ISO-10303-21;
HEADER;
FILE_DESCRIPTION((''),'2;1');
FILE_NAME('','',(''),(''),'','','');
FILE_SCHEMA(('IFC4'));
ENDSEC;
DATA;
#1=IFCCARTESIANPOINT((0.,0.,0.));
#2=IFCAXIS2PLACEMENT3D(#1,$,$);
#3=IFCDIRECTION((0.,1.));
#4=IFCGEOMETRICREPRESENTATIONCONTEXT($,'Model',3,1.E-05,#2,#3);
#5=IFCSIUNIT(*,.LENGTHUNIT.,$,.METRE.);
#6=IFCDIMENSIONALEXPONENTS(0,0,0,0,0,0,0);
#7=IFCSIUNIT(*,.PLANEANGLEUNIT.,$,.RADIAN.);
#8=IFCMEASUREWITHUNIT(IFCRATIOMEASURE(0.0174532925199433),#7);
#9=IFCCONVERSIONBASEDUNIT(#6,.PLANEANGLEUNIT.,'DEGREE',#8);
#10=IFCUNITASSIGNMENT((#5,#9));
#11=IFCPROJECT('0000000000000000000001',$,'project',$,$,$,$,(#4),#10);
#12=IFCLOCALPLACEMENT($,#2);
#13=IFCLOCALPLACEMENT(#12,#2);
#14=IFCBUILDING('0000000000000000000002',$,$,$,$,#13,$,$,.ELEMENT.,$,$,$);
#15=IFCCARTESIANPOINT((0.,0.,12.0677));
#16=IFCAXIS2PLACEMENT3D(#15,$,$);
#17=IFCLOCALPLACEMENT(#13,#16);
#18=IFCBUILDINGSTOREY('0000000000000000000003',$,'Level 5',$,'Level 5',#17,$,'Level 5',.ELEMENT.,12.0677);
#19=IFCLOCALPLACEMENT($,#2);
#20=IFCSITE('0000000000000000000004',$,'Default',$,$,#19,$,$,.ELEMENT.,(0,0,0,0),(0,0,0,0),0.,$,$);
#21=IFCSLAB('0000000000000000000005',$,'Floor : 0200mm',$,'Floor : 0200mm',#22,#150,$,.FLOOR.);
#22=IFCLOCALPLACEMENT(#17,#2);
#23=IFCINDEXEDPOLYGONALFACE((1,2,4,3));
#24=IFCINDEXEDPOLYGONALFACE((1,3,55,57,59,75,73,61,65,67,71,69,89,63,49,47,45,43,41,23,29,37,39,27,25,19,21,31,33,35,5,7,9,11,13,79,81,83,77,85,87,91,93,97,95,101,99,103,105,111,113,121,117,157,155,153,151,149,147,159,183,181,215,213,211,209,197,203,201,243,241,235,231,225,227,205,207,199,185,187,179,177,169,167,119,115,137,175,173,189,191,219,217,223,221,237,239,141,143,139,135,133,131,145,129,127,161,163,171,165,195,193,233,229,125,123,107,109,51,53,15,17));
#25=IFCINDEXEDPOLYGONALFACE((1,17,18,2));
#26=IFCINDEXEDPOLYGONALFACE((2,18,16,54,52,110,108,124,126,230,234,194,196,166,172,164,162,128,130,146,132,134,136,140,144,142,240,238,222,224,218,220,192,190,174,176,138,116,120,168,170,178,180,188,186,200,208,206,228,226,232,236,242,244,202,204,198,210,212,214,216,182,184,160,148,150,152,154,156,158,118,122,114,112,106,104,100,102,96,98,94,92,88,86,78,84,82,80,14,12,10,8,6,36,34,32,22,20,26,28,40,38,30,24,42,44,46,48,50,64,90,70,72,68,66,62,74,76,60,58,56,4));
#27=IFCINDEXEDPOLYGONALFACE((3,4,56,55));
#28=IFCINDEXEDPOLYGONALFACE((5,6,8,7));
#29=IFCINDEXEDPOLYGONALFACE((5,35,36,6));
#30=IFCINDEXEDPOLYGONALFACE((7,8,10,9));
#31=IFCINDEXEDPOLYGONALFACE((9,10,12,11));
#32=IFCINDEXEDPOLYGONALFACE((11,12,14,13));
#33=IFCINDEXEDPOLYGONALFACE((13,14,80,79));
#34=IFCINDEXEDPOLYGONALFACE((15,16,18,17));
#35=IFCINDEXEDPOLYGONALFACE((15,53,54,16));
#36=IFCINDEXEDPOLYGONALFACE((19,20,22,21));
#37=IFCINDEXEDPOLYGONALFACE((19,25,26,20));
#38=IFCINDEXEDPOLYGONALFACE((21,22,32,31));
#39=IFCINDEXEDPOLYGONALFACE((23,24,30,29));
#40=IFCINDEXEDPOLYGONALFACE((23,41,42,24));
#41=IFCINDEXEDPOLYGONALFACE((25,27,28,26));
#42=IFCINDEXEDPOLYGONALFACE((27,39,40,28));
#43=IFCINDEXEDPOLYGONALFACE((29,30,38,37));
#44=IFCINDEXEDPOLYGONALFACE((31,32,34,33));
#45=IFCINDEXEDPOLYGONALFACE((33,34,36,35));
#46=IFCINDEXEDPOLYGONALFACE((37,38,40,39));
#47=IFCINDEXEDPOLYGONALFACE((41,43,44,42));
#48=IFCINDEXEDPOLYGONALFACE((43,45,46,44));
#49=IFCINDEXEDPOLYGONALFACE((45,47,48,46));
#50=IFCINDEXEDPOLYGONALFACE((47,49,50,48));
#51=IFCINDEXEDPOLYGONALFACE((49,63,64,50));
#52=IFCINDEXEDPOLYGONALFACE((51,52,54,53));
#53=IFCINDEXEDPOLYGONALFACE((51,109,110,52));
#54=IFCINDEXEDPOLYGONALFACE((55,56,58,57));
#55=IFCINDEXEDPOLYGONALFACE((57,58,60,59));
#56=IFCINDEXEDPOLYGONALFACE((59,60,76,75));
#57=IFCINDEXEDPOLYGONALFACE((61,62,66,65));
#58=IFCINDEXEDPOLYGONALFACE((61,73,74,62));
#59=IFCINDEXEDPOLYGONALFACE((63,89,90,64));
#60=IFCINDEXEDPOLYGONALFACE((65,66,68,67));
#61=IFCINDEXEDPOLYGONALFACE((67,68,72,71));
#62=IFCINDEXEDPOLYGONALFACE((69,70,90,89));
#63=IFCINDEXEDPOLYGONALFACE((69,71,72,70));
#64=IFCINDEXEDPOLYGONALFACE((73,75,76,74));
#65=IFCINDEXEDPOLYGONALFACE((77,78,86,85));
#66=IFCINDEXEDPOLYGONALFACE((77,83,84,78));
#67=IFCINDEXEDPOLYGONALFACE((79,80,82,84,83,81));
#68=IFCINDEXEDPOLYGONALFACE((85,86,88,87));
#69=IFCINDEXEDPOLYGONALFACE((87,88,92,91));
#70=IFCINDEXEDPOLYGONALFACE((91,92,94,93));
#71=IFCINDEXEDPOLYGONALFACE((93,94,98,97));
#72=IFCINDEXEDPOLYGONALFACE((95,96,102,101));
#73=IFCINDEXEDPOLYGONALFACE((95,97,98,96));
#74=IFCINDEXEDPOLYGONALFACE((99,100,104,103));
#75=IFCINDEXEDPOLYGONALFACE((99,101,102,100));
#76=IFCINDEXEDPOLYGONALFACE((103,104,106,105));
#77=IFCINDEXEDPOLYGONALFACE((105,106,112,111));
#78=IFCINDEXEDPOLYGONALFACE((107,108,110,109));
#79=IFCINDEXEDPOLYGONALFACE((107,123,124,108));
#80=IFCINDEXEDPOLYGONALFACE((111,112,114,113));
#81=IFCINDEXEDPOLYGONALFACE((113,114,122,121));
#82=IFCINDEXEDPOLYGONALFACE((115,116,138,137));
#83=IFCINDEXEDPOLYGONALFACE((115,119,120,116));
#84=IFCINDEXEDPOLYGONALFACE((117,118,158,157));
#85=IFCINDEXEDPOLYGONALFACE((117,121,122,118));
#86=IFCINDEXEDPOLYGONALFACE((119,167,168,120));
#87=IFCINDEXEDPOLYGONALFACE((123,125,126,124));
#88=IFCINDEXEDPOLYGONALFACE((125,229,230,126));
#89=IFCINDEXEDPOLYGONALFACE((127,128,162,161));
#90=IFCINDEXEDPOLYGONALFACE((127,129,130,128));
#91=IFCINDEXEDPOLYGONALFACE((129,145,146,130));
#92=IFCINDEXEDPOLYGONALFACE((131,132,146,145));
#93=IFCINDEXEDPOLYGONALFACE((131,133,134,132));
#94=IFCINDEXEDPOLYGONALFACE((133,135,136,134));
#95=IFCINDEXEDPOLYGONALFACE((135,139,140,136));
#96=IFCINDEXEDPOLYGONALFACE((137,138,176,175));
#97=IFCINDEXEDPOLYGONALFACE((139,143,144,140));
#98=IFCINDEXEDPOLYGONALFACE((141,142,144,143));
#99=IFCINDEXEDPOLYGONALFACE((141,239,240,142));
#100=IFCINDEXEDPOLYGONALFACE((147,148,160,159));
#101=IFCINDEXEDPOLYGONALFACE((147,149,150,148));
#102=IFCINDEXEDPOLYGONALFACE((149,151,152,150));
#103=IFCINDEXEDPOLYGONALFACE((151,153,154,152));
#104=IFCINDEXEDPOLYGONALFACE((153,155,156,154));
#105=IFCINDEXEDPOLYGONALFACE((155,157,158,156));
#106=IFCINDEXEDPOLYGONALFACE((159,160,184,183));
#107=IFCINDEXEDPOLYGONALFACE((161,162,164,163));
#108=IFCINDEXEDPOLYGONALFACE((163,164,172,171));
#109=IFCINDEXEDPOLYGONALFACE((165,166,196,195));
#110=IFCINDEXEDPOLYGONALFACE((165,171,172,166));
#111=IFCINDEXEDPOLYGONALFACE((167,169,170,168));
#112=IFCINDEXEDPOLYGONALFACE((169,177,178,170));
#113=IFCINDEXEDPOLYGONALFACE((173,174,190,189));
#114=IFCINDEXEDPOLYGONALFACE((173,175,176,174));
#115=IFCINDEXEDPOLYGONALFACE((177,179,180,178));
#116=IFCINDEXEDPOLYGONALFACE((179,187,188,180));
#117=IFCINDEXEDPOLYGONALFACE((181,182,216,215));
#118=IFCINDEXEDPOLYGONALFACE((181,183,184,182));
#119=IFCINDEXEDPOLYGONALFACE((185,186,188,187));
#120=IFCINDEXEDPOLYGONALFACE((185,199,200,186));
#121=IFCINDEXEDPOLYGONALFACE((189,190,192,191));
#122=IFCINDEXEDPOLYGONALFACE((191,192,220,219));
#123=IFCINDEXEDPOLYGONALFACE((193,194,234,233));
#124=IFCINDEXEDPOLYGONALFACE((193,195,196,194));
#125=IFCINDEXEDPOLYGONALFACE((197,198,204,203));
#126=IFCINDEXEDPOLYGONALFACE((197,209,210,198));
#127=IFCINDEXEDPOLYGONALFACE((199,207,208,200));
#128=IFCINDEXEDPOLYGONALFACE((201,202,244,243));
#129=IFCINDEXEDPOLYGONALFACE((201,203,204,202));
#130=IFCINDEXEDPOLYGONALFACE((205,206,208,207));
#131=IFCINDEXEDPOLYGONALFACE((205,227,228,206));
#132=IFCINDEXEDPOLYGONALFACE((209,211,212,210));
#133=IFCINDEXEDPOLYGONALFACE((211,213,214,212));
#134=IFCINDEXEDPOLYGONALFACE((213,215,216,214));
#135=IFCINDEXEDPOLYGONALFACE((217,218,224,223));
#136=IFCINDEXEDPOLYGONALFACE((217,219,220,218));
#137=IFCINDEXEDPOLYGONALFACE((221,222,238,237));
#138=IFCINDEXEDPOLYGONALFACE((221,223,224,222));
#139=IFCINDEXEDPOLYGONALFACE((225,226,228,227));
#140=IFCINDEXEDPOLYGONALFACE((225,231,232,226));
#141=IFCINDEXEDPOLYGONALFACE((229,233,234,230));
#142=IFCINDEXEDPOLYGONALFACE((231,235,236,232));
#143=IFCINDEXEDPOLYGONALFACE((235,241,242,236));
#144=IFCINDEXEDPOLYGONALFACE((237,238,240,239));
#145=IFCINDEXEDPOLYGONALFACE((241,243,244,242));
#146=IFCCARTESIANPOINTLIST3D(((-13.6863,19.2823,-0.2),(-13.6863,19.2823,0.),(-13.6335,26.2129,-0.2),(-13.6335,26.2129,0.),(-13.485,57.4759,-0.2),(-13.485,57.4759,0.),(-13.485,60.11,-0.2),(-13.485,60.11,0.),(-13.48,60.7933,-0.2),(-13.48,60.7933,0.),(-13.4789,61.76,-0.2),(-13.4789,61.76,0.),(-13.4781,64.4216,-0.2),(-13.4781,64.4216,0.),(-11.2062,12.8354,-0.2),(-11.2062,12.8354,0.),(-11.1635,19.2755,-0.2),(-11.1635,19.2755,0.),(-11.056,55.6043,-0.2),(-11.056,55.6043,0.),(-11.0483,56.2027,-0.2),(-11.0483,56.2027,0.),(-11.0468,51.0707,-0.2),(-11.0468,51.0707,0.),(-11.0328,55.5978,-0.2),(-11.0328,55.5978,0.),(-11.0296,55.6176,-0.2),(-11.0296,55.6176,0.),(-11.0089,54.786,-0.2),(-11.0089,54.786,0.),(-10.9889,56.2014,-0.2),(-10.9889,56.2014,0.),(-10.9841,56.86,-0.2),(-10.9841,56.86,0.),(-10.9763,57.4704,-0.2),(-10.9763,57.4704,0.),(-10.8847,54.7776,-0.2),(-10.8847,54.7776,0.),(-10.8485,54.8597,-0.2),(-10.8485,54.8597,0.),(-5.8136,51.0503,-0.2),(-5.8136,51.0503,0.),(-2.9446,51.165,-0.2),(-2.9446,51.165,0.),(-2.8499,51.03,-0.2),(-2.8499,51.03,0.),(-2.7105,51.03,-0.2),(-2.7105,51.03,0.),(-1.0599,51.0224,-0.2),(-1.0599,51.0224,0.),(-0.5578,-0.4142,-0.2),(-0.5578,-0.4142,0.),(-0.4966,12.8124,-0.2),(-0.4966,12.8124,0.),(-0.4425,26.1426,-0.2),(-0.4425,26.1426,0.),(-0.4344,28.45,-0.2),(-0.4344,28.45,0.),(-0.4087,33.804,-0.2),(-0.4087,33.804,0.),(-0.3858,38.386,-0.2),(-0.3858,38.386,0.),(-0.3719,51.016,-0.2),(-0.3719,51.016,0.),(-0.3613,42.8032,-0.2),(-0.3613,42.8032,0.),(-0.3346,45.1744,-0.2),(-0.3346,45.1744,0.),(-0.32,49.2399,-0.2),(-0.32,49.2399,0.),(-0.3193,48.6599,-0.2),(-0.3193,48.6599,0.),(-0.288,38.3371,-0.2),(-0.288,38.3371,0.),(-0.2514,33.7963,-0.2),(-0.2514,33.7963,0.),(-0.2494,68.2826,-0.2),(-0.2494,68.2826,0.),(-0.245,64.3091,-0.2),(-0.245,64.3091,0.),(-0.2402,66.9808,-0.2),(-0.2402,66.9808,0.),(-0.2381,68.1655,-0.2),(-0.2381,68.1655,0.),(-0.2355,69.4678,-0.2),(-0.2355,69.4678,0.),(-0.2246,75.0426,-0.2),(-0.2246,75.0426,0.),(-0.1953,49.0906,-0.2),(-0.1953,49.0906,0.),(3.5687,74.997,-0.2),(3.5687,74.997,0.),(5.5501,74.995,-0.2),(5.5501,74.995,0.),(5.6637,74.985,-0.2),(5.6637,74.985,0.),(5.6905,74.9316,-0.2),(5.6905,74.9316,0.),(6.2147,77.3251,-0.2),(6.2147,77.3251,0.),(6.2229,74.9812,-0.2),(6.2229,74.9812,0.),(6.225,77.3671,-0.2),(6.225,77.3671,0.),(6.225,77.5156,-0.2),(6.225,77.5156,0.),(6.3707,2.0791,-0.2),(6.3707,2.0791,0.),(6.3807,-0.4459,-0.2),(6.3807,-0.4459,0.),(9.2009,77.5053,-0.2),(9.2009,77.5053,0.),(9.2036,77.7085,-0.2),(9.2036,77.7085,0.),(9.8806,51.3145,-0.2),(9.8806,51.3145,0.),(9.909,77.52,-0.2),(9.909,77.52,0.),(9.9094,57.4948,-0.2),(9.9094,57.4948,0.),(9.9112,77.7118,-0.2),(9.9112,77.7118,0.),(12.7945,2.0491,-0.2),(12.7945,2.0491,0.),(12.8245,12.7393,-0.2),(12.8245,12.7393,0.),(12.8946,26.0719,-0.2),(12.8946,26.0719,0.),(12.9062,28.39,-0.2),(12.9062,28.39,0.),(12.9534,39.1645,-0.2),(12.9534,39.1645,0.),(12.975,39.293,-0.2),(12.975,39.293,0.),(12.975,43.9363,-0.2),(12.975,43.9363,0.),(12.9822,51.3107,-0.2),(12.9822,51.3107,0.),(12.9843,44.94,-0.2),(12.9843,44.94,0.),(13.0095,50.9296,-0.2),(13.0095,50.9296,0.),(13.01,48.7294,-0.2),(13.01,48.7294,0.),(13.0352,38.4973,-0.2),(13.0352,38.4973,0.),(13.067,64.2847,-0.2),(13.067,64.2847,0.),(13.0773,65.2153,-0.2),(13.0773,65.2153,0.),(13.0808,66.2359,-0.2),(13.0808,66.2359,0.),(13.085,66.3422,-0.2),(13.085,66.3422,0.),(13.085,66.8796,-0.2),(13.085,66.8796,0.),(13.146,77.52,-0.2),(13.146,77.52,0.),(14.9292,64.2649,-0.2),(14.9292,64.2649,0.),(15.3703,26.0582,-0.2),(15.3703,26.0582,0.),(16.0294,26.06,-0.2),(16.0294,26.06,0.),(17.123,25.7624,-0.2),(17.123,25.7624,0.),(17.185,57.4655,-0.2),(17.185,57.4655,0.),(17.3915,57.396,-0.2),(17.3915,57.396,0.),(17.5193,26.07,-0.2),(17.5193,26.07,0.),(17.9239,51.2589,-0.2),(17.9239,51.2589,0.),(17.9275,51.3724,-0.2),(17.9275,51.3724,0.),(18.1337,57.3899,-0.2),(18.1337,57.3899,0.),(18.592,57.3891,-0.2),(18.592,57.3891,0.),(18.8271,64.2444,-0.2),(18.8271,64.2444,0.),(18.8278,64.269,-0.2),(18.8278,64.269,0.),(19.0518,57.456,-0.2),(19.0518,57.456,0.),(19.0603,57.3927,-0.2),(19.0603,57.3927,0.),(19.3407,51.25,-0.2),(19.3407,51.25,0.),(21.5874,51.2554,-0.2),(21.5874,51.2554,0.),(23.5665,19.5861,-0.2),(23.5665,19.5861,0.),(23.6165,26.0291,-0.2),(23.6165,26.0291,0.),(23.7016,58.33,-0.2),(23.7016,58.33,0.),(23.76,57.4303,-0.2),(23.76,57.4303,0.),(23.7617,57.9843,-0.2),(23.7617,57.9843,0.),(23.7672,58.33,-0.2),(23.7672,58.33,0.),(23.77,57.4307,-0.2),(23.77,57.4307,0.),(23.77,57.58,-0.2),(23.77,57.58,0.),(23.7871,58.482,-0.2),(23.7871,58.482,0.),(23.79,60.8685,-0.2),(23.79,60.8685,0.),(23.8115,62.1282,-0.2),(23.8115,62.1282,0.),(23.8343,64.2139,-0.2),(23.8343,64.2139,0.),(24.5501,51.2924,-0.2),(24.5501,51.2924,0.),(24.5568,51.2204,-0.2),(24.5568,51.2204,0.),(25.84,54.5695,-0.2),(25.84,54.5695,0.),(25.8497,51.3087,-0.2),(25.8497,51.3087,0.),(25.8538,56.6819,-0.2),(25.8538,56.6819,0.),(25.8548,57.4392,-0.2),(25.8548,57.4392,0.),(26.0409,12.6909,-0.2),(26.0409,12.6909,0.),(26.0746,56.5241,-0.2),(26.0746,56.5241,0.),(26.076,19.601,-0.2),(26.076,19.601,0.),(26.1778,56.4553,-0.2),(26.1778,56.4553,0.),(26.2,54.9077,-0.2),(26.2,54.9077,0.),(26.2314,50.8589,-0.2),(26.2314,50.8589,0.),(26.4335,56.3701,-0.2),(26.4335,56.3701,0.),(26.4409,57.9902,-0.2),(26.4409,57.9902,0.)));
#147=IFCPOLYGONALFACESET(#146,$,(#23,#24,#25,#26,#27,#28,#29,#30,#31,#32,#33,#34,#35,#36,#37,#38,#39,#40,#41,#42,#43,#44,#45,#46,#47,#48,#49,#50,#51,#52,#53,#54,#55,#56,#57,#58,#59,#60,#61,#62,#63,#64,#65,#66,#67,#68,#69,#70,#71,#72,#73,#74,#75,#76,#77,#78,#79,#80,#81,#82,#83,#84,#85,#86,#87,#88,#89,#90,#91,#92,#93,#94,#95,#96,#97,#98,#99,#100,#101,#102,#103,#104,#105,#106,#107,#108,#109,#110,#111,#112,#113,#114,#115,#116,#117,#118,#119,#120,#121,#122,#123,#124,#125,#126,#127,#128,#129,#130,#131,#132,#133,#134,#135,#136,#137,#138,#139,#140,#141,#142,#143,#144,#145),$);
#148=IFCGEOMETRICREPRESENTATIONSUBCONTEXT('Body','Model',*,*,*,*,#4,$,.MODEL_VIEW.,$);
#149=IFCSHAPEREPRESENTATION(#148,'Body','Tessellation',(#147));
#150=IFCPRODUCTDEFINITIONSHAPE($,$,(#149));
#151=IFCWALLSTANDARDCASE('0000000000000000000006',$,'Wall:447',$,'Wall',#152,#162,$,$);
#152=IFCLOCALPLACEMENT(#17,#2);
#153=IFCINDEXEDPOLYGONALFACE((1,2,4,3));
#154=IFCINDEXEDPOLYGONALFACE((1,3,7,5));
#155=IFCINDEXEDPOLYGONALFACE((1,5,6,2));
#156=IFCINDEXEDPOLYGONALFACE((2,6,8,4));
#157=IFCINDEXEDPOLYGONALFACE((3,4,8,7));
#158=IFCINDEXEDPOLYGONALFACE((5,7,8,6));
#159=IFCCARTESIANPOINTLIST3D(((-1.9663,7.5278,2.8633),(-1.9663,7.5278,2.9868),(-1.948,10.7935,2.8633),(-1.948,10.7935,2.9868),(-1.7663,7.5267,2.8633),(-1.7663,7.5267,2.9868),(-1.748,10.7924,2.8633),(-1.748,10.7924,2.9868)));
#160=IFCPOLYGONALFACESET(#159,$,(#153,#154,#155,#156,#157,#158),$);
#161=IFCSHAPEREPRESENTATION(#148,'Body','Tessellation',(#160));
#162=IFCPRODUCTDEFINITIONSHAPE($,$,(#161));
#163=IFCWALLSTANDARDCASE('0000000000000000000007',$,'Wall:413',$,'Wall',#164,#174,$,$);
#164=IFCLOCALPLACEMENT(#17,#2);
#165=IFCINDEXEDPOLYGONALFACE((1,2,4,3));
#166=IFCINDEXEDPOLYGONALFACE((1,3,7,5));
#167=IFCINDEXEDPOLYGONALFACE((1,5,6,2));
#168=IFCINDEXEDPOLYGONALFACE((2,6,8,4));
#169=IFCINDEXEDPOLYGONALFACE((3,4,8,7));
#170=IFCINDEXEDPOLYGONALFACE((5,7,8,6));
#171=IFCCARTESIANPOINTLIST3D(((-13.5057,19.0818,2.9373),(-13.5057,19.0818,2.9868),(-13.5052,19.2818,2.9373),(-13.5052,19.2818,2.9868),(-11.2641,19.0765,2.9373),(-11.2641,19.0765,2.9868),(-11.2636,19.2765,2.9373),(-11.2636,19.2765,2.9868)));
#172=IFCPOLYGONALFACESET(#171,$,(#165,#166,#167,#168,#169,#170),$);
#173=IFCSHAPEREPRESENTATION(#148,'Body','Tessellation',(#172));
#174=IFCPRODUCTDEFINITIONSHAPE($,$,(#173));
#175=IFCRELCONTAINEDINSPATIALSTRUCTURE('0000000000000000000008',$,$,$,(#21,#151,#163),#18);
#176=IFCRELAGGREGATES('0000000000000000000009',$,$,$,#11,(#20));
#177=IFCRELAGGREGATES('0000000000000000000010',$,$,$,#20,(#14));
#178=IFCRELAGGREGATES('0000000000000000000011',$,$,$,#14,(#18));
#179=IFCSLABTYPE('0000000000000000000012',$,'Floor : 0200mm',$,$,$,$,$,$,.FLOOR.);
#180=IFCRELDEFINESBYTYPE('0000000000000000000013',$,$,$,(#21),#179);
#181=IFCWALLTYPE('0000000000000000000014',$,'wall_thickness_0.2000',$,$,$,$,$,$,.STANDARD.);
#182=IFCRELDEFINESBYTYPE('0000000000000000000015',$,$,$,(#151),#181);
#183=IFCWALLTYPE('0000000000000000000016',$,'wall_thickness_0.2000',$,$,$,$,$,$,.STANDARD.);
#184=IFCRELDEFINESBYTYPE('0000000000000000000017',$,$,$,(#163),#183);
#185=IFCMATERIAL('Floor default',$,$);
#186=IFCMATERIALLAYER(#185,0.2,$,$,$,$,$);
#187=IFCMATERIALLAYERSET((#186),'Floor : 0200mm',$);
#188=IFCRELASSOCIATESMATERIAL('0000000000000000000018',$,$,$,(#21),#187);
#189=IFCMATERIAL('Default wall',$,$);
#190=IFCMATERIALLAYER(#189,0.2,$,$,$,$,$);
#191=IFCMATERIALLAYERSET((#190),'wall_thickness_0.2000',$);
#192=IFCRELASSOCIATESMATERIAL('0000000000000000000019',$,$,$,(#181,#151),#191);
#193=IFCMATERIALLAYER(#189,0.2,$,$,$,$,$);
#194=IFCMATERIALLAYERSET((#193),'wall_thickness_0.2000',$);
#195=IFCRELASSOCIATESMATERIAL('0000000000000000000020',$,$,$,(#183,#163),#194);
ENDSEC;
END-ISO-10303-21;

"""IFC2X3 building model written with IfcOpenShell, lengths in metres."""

from ifc_helpers import new_model, entity, si_unit, converted_unit, direction, frame, origin, place, context, subcontext, project, spatial, polyline, outline, extrude, material, layer, layer_set, layer_usage, type_object, element, save


model = new_model("IFC2X3")

# Units and contexts
model_context = context("Model", 3, precision=1e-05, world=origin(), true_north=direction((0.0, 1.0)))
body_context = subcontext(model_context, "Body", "Model", "MODEL_VIEW")
ifc_project = project(units=[si_unit("LENGTHUNIT", "METRE"), converted_unit("PLANEANGLEUNIT", "DEGREE", entity("IfcRatioMeasure", 0.0174532925199433), si_unit("PLANEANGLEUNIT", "RADIAN"), dimensions=[0, 0, 0, 0, 0, 0, 0])], contexts=[model_context])

# Site, building, storey
site_placement = place(None, origin())
site = spatial("IfcSite", under=ifc_project, at=site_placement, Name="Default", CompositionType="ELEMENT", RefLatitude=(0, 0, 0, 0), RefLongitude=(0, 0, 0, 0), RefElevation=0.0)
placement_1 = place(None, origin())
building_placement = place(placement_1, origin())
building = spatial("IfcBuilding", under=site, at=building_placement, CompositionType="ELEMENT")
storey_placement = place(building_placement, frame((0.0, 0.0, 12.0677)))
storey = spatial("IfcBuildingStorey", under=building, at=storey_placement, Name="Level 5", ObjectType="Level 5", LongName="Level 5", CompositionType="ELEMENT", Elevation=12.0677)

# Slab
ifc_material_1 = material(Name="Floor default")
ifc_layer_1 = layer(ifc_material_1, 0.2)
ifc_layer_set_1 = layer_set([ifc_layer_1], Name="Floor : 0200mm")
ifc_layer_usage_1 = layer_usage(ifc_layer_set_1, "AXIS3", "POSITIVE", 0.0)
slab_type = type_object("IfcSlabType", Name="Floor : 0200mm", PredefinedType="FLOOR")
slab_placement = place(storey_placement, origin())
element("IfcSlab", 1, at=slab_placement, inside=storey, type_object=slab_type, material=ifc_layer_usage_1, Name="Floor : 0200mm", ObjectType="Floor : 0200mm", PredefinedType="FLOOR", context=body_context, shape_type="SweptSolid", body=[
    extrude(outline(polyline([(-0.4087, 33.804), (-0.2514, 33.7963), (-0.288, 38.3371), (-0.3858, 38.386), (-0.3613, 42.8032), (-0.3346, 45.1744), (-0.3193, 48.6599), (-0.32, 49.2399), (-0.1953, 49.0906), (-0.3719, 51.016), (-1.0599, 51.0224), (-2.7105, 51.03), (-2.8499, 51.03), (-2.9446, 51.165), (-5.8136, 51.0503), (-11.0468, 51.0707), (-11.0089, 54.786), (-10.8847, 54.7776), (-10.8485, 54.8597), (-11.0296, 55.6176), (-11.0328, 55.5978), (-11.056, 55.6043), (-11.0483, 56.2027), (-10.9889, 56.2014), (-10.9841, 56.86), (-10.9763, 57.4704), (-13.485, 57.4759), (-13.485, 60.11), (-13.48, 60.7933), (-13.4789, 61.76), (-13.4781, 64.4216), (-0.245, 64.3091), (-0.2402, 66.9808), (-0.2381, 68.1655), (-0.2494, 68.2826), (-0.2355, 69.4678), (-0.2246, 75.0426), (3.5687, 74.997), (5.5501, 74.995), (5.6905, 74.9316), (5.6637, 74.985), (6.2229, 74.9812), (6.2147, 77.3251), (6.225, 77.3671), (6.225, 77.5156), (9.2009, 77.5053), (9.2036, 77.7085), (9.9112, 77.7118), (9.909, 77.52), (13.146, 77.52), (13.085, 66.8796), (13.085, 66.3422), (13.0808, 66.2359), (13.0773, 65.2153), (13.067, 64.2847), (14.9292, 64.2649), (18.8278, 64.269), (18.8271, 64.2444), (23.8343, 64.2139), (23.8115, 62.1282), (23.79, 60.8685), (23.7871, 58.482), (23.7016, 58.33), (23.7672, 58.33), (23.7617, 57.9843), (26.4409, 57.9902), (26.4335, 56.3701), (26.1778, 56.4553), (26.0746, 56.5241), (25.8538, 56.6819), (25.8548, 57.4392), (23.77, 57.4307), (23.77, 57.58), (23.76, 57.4303), (19.0518, 57.456), (19.0603, 57.3927), (18.592, 57.3891), (18.1337, 57.3899), (17.3915, 57.396), (17.185, 57.4655), (9.9094, 57.4948), (9.8806, 51.3145), (12.9822, 51.3107), (17.9275, 51.3724), (17.9239, 51.2589), (19.3407, 51.25), (21.5874, 51.2554), (24.5568, 51.2204), (24.5501, 51.2924), (25.8497, 51.3087), (25.84, 54.5695), (26.2, 54.9077), (26.2314, 50.8589), (13.0095, 50.9296), (13.01, 48.7294), (12.9843, 44.94), (12.975, 43.9363), (12.975, 39.293), (12.9534, 39.1645), (13.0352, 38.4973), (12.9062, 28.39), (12.8946, 26.0719), (15.3703, 26.0582), (16.0294, 26.06), (17.5193, 26.07), (17.123, 25.7624), (23.6165, 26.0291), (23.5665, 19.5861), (26.076, 19.601), (26.0409, 12.6909), (12.8245, 12.7393), (12.7945, 2.0491), (6.3707, 2.0791), (6.3807, -0.4459), (-0.5578, -0.4142), (-0.4966, 12.8124), (-11.2062, 12.8354), (-11.1635, 19.2755), (-13.6863, 19.2823), (-13.6335, 26.2129), (-0.4425, 26.1426), (-0.4344, 28.45), (-0.4087, 33.804)])), frame((0.0, 0.0, -0.2), z_axis=(0.0, 0.0, 1.0), x_axis=(1.0, 0.0, 0.0)), (0.0, 0.0, 1.0), 0.2),
])

# Walls
ifc_material_2 = material(Name="Default wall")
ifc_layer_2 = layer(ifc_material_2, 0.2)
ifc_layer_set_2 = layer_set([ifc_layer_2], Name="wall_thickness_0.2000")
ifc_layer_usage_2 = layer_usage(ifc_layer_set_2, "AXIS2", "POSITIVE", -0.1)
wall_type_1 = type_object("IfcWallType", Name="wall_thickness_0.2000", PredefinedType="STANDARD", material=ifc_layer_set_2)
placement_2 = place(building_placement, frame((0.0, 0.0, 14.931)))
wall_1_placement = place(placement_2, frame((-1.848, 10.793, 0.0), z_axis=(0.0, 0.0, 1.0), x_axis=(-0.00563, -0.999984, 0.0)))
element("IfcWallStandardCase", 2, at=wall_1_placement, inside=storey, type_object=wall_type_1, material=ifc_layer_usage_2, Name="Wall:447", ObjectType="Wall", context=body_context, shape_type="SweptSolid", body=[
    extrude(outline(polyline([(3.2657, -0.1), (3.2657, 0.1), (0.0, 0.1), (0.0, -0.1), (3.2657, -0.1)])), origin(), (0.0, 0.0, 1.0), 0.1235),
])
ifc_layer_3 = layer(ifc_material_2, 0.2)
ifc_layer_set_3 = layer_set([ifc_layer_3], Name="wall_thickness_0.2000")
ifc_layer_usage_3 = layer_usage(ifc_layer_set_3, "AXIS2", "POSITIVE", -0.1)
wall_type_2 = type_object("IfcWallType", Name="wall_thickness_0.2000", PredefinedType="STANDARD", material=ifc_layer_set_3)
placement_3 = place(building_placement, frame((0.0, 0.0, 15.005)))
wall_2_placement = place(placement_3, frame((-13.5054, 19.1818, 0.0), z_axis=(0.0, 0.0, 1.0), x_axis=(0.999997, -0.002382, 0.0)))
element("IfcWallStandardCase", 3, at=wall_2_placement, inside=storey, type_object=wall_type_2, material=ifc_layer_usage_3, Name="Wall:413", ObjectType="Wall", context=body_context, shape_type="SweptSolid", body=[
    extrude(outline(polyline([(2.2416, -0.1), (2.2416, 0.1), (0.0, 0.1), (0.0, -0.1), (2.2416, -0.1)])), origin(), (0.0, 0.0, 1.0), 0.0495),
])

save(model, "model.ifc")
